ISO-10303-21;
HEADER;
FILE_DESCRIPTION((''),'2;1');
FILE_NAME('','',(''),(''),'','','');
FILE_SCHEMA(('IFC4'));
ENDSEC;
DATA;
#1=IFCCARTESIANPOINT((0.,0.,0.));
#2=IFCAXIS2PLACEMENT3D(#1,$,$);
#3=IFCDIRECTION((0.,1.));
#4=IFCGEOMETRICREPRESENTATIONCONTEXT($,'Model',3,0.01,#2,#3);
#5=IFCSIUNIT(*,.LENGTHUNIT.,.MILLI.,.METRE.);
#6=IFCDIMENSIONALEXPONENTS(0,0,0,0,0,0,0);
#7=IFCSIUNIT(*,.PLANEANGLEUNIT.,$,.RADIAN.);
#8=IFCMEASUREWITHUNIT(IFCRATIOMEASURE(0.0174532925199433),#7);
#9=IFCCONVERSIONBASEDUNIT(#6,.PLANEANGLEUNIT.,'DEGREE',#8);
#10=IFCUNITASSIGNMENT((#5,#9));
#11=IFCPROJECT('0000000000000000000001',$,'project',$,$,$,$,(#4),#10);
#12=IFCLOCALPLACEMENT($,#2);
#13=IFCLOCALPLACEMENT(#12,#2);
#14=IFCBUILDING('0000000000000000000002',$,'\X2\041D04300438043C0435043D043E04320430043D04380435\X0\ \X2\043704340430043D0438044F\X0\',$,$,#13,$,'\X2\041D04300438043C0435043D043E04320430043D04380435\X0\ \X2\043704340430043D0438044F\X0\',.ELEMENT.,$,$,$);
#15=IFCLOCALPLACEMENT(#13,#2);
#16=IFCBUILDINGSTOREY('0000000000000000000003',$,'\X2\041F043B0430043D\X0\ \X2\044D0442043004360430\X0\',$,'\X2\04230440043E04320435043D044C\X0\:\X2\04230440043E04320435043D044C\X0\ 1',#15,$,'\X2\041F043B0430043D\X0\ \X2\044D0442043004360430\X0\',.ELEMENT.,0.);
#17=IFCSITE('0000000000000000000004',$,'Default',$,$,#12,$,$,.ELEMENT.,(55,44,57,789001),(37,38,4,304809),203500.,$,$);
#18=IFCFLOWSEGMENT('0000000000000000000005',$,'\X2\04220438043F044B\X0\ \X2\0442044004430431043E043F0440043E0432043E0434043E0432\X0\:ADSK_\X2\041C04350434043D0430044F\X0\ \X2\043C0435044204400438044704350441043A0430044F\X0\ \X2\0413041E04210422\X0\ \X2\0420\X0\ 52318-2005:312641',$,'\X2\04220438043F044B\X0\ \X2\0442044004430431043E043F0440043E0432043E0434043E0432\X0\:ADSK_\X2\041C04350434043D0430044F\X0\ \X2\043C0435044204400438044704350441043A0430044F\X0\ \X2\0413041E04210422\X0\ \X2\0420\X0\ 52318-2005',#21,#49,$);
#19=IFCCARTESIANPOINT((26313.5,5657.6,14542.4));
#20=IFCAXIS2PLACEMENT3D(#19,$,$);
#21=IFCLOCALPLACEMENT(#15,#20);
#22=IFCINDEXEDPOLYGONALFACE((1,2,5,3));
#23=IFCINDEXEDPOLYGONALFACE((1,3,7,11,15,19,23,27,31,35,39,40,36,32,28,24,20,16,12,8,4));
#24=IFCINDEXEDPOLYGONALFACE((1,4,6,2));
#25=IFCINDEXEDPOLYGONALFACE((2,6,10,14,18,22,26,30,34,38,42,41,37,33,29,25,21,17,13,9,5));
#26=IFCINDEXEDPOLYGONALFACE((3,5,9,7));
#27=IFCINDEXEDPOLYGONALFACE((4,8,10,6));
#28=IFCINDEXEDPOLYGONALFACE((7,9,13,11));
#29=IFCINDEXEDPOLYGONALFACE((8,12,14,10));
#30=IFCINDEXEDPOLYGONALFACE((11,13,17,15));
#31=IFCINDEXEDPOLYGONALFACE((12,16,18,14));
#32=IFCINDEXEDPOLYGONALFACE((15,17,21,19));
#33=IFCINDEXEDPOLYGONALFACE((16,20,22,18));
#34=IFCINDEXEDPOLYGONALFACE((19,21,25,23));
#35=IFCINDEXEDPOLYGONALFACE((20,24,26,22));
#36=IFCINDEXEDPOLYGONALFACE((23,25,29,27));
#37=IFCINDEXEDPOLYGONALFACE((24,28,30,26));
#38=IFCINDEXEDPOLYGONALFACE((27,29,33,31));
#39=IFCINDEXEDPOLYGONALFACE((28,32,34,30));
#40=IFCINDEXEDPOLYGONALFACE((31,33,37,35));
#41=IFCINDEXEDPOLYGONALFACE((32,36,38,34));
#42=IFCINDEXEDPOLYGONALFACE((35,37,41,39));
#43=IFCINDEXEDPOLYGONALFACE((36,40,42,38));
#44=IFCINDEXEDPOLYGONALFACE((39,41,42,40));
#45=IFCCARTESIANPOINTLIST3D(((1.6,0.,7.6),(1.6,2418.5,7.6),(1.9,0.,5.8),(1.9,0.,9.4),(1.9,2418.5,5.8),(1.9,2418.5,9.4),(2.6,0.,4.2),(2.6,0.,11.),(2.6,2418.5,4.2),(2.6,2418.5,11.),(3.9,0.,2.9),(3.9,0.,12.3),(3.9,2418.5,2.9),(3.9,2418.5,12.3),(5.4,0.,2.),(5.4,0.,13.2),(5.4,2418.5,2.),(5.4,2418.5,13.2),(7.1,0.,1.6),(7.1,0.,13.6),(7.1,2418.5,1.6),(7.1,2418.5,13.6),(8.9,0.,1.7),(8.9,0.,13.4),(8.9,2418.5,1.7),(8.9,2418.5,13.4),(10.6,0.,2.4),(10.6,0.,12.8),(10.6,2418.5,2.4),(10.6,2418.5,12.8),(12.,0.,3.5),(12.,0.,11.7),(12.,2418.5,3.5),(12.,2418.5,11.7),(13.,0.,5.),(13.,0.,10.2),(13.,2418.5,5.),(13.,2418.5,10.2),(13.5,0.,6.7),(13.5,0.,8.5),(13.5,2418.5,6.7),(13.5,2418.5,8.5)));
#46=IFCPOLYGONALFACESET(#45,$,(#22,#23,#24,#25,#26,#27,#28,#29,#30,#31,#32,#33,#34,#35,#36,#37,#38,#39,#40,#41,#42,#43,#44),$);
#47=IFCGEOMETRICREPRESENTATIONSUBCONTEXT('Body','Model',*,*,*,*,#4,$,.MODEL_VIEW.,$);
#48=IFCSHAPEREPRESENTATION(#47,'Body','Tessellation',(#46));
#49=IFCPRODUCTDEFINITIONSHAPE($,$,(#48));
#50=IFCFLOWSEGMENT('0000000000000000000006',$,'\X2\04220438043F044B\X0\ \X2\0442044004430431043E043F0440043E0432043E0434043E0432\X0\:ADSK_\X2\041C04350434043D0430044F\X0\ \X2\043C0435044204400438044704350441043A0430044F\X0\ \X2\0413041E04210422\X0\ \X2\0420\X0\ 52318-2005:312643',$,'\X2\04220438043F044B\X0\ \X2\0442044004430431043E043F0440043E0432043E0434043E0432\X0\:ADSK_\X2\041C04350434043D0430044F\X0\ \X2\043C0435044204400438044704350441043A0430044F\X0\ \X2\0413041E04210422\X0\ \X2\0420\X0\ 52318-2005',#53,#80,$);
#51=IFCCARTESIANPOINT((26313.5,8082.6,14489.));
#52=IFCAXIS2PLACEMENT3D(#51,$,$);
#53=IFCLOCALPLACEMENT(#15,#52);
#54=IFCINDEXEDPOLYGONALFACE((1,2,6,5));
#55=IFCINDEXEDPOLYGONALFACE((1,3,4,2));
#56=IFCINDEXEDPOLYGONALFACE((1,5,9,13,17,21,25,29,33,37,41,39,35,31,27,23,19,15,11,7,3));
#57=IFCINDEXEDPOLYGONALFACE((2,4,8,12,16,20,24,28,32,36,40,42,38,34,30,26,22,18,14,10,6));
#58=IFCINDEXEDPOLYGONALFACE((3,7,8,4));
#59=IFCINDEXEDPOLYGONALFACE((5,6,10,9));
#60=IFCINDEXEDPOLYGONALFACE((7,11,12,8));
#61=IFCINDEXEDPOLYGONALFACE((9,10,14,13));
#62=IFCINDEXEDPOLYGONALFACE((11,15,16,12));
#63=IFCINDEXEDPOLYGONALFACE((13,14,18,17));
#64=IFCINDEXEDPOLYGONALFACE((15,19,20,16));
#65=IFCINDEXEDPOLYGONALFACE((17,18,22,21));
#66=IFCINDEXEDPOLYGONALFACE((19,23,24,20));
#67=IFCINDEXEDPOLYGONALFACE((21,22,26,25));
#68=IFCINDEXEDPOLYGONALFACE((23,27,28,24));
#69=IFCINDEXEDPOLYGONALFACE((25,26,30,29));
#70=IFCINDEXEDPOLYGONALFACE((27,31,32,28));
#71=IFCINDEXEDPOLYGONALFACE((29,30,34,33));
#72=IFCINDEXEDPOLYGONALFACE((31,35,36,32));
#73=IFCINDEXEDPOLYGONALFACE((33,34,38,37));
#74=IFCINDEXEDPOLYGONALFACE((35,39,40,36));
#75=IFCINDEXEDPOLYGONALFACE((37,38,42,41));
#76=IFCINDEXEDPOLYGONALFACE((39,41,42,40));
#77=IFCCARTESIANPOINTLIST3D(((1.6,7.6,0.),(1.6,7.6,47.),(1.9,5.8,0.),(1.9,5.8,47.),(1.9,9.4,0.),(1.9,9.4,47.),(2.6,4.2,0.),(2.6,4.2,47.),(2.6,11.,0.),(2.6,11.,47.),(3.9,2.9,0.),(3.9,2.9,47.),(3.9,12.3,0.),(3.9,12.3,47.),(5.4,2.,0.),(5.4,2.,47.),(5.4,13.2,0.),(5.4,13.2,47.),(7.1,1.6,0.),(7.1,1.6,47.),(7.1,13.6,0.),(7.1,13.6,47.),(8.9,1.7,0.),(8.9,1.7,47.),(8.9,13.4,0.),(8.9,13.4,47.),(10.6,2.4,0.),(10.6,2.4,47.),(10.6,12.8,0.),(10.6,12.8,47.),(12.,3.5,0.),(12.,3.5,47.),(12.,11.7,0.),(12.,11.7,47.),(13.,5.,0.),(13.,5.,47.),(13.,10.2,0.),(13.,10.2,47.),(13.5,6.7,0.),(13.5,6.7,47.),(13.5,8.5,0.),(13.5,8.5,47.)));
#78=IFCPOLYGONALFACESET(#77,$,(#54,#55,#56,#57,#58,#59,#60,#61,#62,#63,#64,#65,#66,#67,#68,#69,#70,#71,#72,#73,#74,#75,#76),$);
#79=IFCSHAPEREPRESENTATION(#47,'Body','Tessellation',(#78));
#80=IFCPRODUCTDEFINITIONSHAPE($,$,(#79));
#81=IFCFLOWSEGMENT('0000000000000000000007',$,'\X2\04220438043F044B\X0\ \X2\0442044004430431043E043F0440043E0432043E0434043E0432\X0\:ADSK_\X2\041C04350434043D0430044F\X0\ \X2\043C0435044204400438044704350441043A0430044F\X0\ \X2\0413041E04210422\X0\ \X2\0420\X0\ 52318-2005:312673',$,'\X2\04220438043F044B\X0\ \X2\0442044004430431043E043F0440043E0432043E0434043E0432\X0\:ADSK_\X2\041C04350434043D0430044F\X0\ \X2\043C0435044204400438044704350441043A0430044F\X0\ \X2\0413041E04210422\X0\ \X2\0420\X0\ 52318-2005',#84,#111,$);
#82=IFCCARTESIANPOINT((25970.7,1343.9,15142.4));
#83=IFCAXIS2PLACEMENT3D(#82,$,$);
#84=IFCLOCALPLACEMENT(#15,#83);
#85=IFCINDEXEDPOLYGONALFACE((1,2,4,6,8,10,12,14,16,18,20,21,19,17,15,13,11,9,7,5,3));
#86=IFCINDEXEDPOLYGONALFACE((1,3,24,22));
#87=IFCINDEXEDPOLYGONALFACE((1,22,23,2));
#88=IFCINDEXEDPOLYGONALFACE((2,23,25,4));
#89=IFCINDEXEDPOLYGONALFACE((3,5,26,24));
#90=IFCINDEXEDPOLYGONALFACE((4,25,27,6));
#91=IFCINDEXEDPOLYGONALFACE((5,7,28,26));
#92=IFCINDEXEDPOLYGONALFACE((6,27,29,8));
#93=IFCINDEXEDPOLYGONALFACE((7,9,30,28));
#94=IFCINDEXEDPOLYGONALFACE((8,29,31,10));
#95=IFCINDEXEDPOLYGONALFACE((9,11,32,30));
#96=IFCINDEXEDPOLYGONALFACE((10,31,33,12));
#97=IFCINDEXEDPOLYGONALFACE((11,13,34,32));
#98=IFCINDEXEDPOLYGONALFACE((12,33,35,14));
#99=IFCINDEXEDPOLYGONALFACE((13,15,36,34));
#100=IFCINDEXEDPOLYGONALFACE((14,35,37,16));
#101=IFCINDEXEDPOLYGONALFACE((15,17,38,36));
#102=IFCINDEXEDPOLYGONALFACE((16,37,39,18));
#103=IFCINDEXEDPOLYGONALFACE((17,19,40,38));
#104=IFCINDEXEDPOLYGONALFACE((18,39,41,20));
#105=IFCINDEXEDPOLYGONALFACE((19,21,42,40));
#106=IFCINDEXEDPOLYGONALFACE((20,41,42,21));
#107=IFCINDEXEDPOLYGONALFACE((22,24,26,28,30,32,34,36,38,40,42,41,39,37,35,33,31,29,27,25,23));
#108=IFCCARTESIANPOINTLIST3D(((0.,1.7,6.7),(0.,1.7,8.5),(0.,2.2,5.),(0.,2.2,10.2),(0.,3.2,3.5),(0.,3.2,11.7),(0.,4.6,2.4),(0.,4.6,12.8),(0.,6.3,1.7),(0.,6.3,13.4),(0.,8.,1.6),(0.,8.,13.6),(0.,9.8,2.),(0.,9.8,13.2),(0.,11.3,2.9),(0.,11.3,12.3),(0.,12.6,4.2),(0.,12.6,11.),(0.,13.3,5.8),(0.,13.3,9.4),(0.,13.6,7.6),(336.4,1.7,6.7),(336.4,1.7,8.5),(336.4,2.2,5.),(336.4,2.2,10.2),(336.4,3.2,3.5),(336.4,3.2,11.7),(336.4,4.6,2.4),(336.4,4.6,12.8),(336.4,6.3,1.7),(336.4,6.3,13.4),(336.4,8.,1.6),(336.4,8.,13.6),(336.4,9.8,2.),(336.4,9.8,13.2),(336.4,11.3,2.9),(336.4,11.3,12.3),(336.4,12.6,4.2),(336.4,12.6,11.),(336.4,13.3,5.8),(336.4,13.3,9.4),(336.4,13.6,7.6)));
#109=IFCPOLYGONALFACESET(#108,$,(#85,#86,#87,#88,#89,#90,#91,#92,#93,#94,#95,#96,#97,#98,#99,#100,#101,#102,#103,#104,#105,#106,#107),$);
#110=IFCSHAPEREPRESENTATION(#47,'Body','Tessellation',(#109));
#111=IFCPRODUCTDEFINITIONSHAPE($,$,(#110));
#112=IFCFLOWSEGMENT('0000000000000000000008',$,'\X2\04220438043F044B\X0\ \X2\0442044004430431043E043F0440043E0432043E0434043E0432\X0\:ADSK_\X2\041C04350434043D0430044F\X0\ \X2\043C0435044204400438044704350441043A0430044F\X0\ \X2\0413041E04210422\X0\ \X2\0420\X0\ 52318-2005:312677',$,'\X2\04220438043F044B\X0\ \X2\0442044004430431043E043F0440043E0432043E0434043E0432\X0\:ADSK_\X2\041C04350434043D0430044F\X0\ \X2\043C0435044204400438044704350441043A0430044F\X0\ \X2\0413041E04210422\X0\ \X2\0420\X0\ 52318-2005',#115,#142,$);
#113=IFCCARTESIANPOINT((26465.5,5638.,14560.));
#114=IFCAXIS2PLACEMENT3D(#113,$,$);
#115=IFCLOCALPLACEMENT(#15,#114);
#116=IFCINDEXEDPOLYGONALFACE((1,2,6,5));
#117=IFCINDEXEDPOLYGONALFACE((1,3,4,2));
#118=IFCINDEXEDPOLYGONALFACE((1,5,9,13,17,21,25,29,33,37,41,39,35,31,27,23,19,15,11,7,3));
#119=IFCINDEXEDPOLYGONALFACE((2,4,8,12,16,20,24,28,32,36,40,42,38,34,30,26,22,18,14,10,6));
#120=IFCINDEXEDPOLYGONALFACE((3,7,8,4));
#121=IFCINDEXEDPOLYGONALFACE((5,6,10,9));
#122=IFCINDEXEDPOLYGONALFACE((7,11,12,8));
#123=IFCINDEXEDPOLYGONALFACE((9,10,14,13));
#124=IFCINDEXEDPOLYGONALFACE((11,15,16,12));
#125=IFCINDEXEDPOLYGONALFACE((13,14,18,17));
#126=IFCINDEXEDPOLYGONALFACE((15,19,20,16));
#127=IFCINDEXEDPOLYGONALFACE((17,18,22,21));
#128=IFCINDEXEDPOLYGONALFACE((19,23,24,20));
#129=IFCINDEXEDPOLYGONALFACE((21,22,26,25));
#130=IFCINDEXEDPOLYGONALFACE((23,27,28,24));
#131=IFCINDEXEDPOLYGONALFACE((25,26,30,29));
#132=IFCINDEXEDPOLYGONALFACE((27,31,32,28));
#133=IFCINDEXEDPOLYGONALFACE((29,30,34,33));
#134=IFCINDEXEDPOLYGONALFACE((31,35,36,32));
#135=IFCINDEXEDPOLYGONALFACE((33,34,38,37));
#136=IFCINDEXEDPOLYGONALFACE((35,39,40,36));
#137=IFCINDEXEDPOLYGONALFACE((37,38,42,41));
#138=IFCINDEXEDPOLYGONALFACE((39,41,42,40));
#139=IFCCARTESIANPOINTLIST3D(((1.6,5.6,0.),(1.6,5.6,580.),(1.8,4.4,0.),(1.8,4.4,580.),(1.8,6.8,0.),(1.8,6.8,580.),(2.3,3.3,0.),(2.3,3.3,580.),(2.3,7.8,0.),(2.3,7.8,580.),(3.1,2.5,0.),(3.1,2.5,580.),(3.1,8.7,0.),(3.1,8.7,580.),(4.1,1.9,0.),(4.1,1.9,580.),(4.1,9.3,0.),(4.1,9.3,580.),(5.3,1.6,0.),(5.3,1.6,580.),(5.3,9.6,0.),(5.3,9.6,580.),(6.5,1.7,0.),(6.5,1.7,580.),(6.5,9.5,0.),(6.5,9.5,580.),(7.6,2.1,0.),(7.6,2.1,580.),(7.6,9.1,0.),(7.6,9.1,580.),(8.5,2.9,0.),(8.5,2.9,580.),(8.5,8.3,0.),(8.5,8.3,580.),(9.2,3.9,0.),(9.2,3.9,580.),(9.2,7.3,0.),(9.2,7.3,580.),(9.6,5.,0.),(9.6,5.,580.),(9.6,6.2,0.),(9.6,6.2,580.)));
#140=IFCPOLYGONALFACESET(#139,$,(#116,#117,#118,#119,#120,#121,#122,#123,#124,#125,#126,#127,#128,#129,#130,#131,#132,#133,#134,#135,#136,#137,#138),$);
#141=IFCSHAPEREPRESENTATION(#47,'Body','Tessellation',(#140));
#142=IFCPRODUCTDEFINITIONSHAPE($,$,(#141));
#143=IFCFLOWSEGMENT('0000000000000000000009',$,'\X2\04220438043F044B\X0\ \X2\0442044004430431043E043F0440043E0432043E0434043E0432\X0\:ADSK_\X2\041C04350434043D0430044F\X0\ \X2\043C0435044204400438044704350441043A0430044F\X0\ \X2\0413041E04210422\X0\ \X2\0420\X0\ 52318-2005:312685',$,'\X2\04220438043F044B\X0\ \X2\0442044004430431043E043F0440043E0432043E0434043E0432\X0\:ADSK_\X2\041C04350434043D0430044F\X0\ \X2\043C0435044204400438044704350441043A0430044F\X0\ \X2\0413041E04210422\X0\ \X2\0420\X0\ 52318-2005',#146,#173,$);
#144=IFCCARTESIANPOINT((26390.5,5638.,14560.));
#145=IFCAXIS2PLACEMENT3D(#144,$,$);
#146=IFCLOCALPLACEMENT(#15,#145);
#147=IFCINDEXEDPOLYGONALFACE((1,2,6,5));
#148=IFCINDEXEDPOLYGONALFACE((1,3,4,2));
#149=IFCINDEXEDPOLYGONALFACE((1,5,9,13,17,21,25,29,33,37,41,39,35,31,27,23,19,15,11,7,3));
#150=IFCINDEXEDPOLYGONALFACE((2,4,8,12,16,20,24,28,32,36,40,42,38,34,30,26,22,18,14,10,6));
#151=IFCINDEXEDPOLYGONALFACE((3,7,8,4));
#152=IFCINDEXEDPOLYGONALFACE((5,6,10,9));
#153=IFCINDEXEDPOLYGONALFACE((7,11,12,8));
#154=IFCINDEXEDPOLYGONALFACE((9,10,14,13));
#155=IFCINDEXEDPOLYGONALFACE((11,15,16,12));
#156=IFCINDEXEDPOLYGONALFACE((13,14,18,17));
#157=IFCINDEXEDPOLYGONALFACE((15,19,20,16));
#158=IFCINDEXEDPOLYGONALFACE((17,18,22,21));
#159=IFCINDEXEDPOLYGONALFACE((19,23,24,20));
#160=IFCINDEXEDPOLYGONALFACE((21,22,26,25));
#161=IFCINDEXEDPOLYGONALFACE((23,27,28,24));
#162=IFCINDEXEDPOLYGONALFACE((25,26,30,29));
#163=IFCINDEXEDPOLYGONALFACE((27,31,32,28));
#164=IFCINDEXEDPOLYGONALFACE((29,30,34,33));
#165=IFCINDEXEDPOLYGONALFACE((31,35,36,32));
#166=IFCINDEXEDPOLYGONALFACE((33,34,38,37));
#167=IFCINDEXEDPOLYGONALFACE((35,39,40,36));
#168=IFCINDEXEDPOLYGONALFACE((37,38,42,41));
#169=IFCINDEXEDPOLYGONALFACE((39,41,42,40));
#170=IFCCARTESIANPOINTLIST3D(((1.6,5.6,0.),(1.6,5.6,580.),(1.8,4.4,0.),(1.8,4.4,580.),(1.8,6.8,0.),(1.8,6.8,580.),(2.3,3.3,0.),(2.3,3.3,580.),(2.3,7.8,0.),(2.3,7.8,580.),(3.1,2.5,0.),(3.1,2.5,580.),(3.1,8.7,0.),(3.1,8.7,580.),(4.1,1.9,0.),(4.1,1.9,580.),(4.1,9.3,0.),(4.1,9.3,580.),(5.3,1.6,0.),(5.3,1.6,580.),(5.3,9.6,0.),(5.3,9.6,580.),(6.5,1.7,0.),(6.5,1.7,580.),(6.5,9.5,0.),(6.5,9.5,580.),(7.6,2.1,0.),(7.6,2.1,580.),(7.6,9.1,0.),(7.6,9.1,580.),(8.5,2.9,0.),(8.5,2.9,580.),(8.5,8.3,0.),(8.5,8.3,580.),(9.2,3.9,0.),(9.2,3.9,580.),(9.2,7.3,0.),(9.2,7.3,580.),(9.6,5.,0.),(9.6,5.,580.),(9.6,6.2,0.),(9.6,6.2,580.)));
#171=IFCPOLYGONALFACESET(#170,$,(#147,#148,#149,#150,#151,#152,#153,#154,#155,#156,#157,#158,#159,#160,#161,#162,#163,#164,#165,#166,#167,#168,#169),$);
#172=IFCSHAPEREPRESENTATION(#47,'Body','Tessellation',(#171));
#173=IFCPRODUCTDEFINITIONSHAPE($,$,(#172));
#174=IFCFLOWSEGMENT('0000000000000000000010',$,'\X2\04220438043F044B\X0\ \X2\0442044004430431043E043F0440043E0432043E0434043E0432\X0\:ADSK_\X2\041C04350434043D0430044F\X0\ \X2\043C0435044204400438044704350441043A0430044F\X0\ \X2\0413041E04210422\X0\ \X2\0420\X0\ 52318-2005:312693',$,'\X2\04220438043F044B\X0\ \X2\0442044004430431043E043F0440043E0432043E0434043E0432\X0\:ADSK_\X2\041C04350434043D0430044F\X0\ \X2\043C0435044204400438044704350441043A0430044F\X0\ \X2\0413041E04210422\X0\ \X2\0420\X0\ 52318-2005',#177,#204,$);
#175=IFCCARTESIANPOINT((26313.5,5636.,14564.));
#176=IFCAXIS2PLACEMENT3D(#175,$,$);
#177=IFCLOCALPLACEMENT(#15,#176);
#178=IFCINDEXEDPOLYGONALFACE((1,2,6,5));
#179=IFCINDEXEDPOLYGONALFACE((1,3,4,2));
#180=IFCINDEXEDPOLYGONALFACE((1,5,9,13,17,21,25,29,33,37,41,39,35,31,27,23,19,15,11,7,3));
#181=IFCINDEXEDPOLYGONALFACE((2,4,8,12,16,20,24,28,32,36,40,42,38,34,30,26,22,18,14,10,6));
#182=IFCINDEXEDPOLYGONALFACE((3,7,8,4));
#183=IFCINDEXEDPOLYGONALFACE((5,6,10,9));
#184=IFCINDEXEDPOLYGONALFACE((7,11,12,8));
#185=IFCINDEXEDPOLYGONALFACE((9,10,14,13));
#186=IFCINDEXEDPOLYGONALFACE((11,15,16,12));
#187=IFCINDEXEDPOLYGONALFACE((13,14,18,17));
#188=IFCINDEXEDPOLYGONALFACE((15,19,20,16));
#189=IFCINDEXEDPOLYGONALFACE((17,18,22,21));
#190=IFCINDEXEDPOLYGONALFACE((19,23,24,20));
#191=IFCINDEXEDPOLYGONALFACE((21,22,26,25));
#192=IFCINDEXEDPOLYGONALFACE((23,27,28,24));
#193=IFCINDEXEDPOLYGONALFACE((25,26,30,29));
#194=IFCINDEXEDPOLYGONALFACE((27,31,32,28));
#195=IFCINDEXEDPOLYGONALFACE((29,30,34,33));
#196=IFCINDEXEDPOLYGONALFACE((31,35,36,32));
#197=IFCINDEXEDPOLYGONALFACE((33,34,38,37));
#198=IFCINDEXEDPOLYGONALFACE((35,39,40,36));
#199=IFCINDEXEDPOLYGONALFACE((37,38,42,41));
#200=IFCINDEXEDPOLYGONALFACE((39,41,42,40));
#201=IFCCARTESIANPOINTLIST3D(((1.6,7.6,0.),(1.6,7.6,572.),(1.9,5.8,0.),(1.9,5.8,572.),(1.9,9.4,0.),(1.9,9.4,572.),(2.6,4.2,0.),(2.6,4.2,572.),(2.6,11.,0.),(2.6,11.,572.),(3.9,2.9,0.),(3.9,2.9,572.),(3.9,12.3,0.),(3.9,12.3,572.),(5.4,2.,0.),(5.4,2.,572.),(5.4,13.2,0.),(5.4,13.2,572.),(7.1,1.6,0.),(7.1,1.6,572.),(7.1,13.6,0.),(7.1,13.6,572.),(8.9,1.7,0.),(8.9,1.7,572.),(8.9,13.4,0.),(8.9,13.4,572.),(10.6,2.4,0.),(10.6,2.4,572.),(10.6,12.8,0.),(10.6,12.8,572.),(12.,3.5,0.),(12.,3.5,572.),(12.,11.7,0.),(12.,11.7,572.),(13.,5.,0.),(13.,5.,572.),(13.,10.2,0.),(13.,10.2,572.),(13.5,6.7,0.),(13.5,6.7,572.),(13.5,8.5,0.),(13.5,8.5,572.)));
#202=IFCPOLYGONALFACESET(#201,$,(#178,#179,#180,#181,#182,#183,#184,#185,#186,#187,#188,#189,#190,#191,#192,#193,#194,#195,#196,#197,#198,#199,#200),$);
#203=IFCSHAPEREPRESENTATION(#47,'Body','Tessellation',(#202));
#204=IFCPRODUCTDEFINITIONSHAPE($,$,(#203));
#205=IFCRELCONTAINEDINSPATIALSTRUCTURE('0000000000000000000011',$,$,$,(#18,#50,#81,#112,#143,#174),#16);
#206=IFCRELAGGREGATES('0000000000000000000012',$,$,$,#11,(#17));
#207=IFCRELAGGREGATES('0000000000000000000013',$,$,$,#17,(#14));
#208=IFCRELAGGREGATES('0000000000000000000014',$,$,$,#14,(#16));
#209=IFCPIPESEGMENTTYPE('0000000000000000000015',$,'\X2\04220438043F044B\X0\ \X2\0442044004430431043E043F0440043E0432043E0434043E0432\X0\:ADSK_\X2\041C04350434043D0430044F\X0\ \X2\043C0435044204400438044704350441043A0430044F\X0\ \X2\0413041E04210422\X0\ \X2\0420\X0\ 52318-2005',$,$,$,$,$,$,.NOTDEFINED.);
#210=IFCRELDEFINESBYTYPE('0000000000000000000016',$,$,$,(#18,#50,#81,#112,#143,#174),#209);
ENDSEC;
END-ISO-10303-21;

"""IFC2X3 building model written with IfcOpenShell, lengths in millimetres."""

from ifc_helpers import new_model, entity, si_unit, converted_unit, direction, frame, frame_2d, origin, origin_2d_with_axis, place, context, subcontext, project, spatial, circle, extrude, type_object, element, save


model = new_model("IFC2X3")

# Units and contexts
model_context = context("Model", 3, precision=0.01, world=origin(), true_north=direction((0.0, 1.0)))
body_context = subcontext(model_context, "Body", "Model", "MODEL_VIEW")
ifc_project = project(units=[si_unit("LENGTHUNIT", "METRE", prefix="MILLI"), converted_unit("PLANEANGLEUNIT", "DEGREE", entity("IfcRatioMeasure", 0.0174532925199433), si_unit("PLANEANGLEUNIT", "RADIAN"), dimensions=[0, 0, 0, 0, 0, 0, 0])], contexts=[model_context])

# Site, building, storey
site_placement = place(None, frame((0.0, 0.0, 0.0)))
site = spatial("IfcSite", under=ifc_project, at=site_placement, Name="Default", CompositionType="ELEMENT", RefLatitude=(55, 44, 57, 789001), RefLongitude=(37, 38, 4, 304809), RefElevation=203500.0)
building_placement = place(site_placement, origin())
building = spatial("IfcBuilding", under=site, at=building_placement, Name="Наименование здания", LongName="Наименование здания", CompositionType="ELEMENT")
storey_placement = place(building_placement, origin())
storey = spatial("IfcBuildingStorey", under=building, at=storey_placement, Name="План этажа", ObjectType="Уровень:Уровень 1", LongName="План этажа", CompositionType="ELEMENT", Elevation=0.0)

# Flow segments
pipe_segment_type = type_object("IfcPipeSegmentType", Name="Типы трубопроводов:ADSK_Медная метрическая ГОСТ Р 52318-2005", PredefinedType="NOTDEFINED")
flow_segment_1_placement = place(storey_placement, frame((26313.5, 5657.6, 14542.4)))
element("IfcFlowSegment", 1, at=flow_segment_1_placement, inside=storey, type_object=pipe_segment_type, Name="Типы трубопроводов:ADSK_Медная метрическая ГОСТ Р 52318-2005:312641", ObjectType="Типы трубопроводов:ADSK_Медная метрическая ГОСТ Р 52318-2005", context=body_context, shape_type="SweptSolid", body=[
    extrude(circle(Radius=6.0, at=frame_2d((0.0, 0.0), x_axis=(1.0, 0.0))), frame((7.6, 0.0, 7.6), z_axis=(0.0, 1.0, 0.0), x_axis=(-1.0, 0.0, 0.0)), (0.0, 0.0, 1.0), 2418.5),
])
flow_segment_2_placement = place(storey_placement, frame((26313.5, 8082.6, 14489.0)))
element("IfcFlowSegment", 2, at=flow_segment_2_placement, inside=storey, type_object=pipe_segment_type, Name="Типы трубопроводов:ADSK_Медная метрическая ГОСТ Р 52318-2005:312643", ObjectType="Типы трубопроводов:ADSK_Медная метрическая ГОСТ Р 52318-2005", context=body_context, shape_type="SweptSolid", body=[
    extrude(circle(Radius=6.0, at=origin_2d_with_axis()), frame((7.6, 7.6, 0.0), z_axis=(0.0, 0.0, 1.0), x_axis=(-1.0, 0.0, 0.0)), (0.0, 0.0, 1.0), 47.0),
])
flow_segment_3_placement = place(storey_placement, frame((25970.7, 1343.9, 15142.4)))
element("IfcFlowSegment", 3, at=flow_segment_3_placement, inside=storey, type_object=pipe_segment_type, Name="Типы трубопроводов:ADSK_Медная метрическая ГОСТ Р 52318-2005:312673", ObjectType="Типы трубопроводов:ADSK_Медная метрическая ГОСТ Р 52318-2005", context=body_context, shape_type="SweptSolid", body=[
    extrude(circle(Radius=6.0, at=frame_2d((0.0, 0.0), x_axis=(1.0, 0.0))), frame((0.0, 7.6, 7.6), z_axis=(1.0, 0.0, 0.0), x_axis=(0.0, 1.0, 0.0)), (0.0, 0.0, 1.0), 336.4),
])
flow_segment_4_placement = place(storey_placement, frame((26465.5, 5638.0, 14560.0)))
element("IfcFlowSegment", 4, at=flow_segment_4_placement, inside=storey, type_object=pipe_segment_type, Name="Типы трубопроводов:ADSK_Медная метрическая ГОСТ Р 52318-2005:312677", ObjectType="Типы трубопроводов:ADSK_Медная метрическая ГОСТ Р 52318-2005", context=body_context, shape_type="SweptSolid", body=[
    extrude(circle(Radius=4.0, at=frame_2d((0.0, 0.0), x_axis=(1.0, 0.0))), frame((5.6, 5.6, 0.0), z_axis=(0.0, 0.0, 1.0), x_axis=(-1.0, 0.0, 0.0)), (0.0, 0.0, 1.0), 580.0),
])
flow_segment_5_placement = place(storey_placement, frame((26390.5, 5638.0, 14560.0)))
element("IfcFlowSegment", 5, at=flow_segment_5_placement, inside=storey, type_object=pipe_segment_type, Name="Типы трубопроводов:ADSK_Медная метрическая ГОСТ Р 52318-2005:312685", ObjectType="Типы трубопроводов:ADSK_Медная метрическая ГОСТ Р 52318-2005", context=body_context, shape_type="SweptSolid", body=[
    extrude(circle(Radius=4.0, at=origin_2d_with_axis()), frame((5.6, 5.6, 0.0), z_axis=(0.0, 0.0, 1.0), x_axis=(-1.0, 0.0, 0.0)), (0.0, 0.0, 1.0), 580.0),
])
flow_segment_6_placement = place(storey_placement, frame((26313.5, 5636.0, 14564.0)))
element("IfcFlowSegment", 6, at=flow_segment_6_placement, inside=storey, type_object=pipe_segment_type, Name="Типы трубопроводов:ADSK_Медная метрическая ГОСТ Р 52318-2005:312693", ObjectType="Типы трубопроводов:ADSK_Медная метрическая ГОСТ Р 52318-2005", context=body_context, shape_type="SweptSolid", body=[
    extrude(circle(Radius=6.0, at=frame_2d((0.0, 0.0), x_axis=(1.0, 0.0))), frame((7.6, 7.6, 0.0), z_axis=(0.0, 0.0, 1.0), x_axis=(-1.0, 0.0, 0.0)), (0.0, 0.0, 1.0), 572.0),
])

save(model, "model.ifc")
